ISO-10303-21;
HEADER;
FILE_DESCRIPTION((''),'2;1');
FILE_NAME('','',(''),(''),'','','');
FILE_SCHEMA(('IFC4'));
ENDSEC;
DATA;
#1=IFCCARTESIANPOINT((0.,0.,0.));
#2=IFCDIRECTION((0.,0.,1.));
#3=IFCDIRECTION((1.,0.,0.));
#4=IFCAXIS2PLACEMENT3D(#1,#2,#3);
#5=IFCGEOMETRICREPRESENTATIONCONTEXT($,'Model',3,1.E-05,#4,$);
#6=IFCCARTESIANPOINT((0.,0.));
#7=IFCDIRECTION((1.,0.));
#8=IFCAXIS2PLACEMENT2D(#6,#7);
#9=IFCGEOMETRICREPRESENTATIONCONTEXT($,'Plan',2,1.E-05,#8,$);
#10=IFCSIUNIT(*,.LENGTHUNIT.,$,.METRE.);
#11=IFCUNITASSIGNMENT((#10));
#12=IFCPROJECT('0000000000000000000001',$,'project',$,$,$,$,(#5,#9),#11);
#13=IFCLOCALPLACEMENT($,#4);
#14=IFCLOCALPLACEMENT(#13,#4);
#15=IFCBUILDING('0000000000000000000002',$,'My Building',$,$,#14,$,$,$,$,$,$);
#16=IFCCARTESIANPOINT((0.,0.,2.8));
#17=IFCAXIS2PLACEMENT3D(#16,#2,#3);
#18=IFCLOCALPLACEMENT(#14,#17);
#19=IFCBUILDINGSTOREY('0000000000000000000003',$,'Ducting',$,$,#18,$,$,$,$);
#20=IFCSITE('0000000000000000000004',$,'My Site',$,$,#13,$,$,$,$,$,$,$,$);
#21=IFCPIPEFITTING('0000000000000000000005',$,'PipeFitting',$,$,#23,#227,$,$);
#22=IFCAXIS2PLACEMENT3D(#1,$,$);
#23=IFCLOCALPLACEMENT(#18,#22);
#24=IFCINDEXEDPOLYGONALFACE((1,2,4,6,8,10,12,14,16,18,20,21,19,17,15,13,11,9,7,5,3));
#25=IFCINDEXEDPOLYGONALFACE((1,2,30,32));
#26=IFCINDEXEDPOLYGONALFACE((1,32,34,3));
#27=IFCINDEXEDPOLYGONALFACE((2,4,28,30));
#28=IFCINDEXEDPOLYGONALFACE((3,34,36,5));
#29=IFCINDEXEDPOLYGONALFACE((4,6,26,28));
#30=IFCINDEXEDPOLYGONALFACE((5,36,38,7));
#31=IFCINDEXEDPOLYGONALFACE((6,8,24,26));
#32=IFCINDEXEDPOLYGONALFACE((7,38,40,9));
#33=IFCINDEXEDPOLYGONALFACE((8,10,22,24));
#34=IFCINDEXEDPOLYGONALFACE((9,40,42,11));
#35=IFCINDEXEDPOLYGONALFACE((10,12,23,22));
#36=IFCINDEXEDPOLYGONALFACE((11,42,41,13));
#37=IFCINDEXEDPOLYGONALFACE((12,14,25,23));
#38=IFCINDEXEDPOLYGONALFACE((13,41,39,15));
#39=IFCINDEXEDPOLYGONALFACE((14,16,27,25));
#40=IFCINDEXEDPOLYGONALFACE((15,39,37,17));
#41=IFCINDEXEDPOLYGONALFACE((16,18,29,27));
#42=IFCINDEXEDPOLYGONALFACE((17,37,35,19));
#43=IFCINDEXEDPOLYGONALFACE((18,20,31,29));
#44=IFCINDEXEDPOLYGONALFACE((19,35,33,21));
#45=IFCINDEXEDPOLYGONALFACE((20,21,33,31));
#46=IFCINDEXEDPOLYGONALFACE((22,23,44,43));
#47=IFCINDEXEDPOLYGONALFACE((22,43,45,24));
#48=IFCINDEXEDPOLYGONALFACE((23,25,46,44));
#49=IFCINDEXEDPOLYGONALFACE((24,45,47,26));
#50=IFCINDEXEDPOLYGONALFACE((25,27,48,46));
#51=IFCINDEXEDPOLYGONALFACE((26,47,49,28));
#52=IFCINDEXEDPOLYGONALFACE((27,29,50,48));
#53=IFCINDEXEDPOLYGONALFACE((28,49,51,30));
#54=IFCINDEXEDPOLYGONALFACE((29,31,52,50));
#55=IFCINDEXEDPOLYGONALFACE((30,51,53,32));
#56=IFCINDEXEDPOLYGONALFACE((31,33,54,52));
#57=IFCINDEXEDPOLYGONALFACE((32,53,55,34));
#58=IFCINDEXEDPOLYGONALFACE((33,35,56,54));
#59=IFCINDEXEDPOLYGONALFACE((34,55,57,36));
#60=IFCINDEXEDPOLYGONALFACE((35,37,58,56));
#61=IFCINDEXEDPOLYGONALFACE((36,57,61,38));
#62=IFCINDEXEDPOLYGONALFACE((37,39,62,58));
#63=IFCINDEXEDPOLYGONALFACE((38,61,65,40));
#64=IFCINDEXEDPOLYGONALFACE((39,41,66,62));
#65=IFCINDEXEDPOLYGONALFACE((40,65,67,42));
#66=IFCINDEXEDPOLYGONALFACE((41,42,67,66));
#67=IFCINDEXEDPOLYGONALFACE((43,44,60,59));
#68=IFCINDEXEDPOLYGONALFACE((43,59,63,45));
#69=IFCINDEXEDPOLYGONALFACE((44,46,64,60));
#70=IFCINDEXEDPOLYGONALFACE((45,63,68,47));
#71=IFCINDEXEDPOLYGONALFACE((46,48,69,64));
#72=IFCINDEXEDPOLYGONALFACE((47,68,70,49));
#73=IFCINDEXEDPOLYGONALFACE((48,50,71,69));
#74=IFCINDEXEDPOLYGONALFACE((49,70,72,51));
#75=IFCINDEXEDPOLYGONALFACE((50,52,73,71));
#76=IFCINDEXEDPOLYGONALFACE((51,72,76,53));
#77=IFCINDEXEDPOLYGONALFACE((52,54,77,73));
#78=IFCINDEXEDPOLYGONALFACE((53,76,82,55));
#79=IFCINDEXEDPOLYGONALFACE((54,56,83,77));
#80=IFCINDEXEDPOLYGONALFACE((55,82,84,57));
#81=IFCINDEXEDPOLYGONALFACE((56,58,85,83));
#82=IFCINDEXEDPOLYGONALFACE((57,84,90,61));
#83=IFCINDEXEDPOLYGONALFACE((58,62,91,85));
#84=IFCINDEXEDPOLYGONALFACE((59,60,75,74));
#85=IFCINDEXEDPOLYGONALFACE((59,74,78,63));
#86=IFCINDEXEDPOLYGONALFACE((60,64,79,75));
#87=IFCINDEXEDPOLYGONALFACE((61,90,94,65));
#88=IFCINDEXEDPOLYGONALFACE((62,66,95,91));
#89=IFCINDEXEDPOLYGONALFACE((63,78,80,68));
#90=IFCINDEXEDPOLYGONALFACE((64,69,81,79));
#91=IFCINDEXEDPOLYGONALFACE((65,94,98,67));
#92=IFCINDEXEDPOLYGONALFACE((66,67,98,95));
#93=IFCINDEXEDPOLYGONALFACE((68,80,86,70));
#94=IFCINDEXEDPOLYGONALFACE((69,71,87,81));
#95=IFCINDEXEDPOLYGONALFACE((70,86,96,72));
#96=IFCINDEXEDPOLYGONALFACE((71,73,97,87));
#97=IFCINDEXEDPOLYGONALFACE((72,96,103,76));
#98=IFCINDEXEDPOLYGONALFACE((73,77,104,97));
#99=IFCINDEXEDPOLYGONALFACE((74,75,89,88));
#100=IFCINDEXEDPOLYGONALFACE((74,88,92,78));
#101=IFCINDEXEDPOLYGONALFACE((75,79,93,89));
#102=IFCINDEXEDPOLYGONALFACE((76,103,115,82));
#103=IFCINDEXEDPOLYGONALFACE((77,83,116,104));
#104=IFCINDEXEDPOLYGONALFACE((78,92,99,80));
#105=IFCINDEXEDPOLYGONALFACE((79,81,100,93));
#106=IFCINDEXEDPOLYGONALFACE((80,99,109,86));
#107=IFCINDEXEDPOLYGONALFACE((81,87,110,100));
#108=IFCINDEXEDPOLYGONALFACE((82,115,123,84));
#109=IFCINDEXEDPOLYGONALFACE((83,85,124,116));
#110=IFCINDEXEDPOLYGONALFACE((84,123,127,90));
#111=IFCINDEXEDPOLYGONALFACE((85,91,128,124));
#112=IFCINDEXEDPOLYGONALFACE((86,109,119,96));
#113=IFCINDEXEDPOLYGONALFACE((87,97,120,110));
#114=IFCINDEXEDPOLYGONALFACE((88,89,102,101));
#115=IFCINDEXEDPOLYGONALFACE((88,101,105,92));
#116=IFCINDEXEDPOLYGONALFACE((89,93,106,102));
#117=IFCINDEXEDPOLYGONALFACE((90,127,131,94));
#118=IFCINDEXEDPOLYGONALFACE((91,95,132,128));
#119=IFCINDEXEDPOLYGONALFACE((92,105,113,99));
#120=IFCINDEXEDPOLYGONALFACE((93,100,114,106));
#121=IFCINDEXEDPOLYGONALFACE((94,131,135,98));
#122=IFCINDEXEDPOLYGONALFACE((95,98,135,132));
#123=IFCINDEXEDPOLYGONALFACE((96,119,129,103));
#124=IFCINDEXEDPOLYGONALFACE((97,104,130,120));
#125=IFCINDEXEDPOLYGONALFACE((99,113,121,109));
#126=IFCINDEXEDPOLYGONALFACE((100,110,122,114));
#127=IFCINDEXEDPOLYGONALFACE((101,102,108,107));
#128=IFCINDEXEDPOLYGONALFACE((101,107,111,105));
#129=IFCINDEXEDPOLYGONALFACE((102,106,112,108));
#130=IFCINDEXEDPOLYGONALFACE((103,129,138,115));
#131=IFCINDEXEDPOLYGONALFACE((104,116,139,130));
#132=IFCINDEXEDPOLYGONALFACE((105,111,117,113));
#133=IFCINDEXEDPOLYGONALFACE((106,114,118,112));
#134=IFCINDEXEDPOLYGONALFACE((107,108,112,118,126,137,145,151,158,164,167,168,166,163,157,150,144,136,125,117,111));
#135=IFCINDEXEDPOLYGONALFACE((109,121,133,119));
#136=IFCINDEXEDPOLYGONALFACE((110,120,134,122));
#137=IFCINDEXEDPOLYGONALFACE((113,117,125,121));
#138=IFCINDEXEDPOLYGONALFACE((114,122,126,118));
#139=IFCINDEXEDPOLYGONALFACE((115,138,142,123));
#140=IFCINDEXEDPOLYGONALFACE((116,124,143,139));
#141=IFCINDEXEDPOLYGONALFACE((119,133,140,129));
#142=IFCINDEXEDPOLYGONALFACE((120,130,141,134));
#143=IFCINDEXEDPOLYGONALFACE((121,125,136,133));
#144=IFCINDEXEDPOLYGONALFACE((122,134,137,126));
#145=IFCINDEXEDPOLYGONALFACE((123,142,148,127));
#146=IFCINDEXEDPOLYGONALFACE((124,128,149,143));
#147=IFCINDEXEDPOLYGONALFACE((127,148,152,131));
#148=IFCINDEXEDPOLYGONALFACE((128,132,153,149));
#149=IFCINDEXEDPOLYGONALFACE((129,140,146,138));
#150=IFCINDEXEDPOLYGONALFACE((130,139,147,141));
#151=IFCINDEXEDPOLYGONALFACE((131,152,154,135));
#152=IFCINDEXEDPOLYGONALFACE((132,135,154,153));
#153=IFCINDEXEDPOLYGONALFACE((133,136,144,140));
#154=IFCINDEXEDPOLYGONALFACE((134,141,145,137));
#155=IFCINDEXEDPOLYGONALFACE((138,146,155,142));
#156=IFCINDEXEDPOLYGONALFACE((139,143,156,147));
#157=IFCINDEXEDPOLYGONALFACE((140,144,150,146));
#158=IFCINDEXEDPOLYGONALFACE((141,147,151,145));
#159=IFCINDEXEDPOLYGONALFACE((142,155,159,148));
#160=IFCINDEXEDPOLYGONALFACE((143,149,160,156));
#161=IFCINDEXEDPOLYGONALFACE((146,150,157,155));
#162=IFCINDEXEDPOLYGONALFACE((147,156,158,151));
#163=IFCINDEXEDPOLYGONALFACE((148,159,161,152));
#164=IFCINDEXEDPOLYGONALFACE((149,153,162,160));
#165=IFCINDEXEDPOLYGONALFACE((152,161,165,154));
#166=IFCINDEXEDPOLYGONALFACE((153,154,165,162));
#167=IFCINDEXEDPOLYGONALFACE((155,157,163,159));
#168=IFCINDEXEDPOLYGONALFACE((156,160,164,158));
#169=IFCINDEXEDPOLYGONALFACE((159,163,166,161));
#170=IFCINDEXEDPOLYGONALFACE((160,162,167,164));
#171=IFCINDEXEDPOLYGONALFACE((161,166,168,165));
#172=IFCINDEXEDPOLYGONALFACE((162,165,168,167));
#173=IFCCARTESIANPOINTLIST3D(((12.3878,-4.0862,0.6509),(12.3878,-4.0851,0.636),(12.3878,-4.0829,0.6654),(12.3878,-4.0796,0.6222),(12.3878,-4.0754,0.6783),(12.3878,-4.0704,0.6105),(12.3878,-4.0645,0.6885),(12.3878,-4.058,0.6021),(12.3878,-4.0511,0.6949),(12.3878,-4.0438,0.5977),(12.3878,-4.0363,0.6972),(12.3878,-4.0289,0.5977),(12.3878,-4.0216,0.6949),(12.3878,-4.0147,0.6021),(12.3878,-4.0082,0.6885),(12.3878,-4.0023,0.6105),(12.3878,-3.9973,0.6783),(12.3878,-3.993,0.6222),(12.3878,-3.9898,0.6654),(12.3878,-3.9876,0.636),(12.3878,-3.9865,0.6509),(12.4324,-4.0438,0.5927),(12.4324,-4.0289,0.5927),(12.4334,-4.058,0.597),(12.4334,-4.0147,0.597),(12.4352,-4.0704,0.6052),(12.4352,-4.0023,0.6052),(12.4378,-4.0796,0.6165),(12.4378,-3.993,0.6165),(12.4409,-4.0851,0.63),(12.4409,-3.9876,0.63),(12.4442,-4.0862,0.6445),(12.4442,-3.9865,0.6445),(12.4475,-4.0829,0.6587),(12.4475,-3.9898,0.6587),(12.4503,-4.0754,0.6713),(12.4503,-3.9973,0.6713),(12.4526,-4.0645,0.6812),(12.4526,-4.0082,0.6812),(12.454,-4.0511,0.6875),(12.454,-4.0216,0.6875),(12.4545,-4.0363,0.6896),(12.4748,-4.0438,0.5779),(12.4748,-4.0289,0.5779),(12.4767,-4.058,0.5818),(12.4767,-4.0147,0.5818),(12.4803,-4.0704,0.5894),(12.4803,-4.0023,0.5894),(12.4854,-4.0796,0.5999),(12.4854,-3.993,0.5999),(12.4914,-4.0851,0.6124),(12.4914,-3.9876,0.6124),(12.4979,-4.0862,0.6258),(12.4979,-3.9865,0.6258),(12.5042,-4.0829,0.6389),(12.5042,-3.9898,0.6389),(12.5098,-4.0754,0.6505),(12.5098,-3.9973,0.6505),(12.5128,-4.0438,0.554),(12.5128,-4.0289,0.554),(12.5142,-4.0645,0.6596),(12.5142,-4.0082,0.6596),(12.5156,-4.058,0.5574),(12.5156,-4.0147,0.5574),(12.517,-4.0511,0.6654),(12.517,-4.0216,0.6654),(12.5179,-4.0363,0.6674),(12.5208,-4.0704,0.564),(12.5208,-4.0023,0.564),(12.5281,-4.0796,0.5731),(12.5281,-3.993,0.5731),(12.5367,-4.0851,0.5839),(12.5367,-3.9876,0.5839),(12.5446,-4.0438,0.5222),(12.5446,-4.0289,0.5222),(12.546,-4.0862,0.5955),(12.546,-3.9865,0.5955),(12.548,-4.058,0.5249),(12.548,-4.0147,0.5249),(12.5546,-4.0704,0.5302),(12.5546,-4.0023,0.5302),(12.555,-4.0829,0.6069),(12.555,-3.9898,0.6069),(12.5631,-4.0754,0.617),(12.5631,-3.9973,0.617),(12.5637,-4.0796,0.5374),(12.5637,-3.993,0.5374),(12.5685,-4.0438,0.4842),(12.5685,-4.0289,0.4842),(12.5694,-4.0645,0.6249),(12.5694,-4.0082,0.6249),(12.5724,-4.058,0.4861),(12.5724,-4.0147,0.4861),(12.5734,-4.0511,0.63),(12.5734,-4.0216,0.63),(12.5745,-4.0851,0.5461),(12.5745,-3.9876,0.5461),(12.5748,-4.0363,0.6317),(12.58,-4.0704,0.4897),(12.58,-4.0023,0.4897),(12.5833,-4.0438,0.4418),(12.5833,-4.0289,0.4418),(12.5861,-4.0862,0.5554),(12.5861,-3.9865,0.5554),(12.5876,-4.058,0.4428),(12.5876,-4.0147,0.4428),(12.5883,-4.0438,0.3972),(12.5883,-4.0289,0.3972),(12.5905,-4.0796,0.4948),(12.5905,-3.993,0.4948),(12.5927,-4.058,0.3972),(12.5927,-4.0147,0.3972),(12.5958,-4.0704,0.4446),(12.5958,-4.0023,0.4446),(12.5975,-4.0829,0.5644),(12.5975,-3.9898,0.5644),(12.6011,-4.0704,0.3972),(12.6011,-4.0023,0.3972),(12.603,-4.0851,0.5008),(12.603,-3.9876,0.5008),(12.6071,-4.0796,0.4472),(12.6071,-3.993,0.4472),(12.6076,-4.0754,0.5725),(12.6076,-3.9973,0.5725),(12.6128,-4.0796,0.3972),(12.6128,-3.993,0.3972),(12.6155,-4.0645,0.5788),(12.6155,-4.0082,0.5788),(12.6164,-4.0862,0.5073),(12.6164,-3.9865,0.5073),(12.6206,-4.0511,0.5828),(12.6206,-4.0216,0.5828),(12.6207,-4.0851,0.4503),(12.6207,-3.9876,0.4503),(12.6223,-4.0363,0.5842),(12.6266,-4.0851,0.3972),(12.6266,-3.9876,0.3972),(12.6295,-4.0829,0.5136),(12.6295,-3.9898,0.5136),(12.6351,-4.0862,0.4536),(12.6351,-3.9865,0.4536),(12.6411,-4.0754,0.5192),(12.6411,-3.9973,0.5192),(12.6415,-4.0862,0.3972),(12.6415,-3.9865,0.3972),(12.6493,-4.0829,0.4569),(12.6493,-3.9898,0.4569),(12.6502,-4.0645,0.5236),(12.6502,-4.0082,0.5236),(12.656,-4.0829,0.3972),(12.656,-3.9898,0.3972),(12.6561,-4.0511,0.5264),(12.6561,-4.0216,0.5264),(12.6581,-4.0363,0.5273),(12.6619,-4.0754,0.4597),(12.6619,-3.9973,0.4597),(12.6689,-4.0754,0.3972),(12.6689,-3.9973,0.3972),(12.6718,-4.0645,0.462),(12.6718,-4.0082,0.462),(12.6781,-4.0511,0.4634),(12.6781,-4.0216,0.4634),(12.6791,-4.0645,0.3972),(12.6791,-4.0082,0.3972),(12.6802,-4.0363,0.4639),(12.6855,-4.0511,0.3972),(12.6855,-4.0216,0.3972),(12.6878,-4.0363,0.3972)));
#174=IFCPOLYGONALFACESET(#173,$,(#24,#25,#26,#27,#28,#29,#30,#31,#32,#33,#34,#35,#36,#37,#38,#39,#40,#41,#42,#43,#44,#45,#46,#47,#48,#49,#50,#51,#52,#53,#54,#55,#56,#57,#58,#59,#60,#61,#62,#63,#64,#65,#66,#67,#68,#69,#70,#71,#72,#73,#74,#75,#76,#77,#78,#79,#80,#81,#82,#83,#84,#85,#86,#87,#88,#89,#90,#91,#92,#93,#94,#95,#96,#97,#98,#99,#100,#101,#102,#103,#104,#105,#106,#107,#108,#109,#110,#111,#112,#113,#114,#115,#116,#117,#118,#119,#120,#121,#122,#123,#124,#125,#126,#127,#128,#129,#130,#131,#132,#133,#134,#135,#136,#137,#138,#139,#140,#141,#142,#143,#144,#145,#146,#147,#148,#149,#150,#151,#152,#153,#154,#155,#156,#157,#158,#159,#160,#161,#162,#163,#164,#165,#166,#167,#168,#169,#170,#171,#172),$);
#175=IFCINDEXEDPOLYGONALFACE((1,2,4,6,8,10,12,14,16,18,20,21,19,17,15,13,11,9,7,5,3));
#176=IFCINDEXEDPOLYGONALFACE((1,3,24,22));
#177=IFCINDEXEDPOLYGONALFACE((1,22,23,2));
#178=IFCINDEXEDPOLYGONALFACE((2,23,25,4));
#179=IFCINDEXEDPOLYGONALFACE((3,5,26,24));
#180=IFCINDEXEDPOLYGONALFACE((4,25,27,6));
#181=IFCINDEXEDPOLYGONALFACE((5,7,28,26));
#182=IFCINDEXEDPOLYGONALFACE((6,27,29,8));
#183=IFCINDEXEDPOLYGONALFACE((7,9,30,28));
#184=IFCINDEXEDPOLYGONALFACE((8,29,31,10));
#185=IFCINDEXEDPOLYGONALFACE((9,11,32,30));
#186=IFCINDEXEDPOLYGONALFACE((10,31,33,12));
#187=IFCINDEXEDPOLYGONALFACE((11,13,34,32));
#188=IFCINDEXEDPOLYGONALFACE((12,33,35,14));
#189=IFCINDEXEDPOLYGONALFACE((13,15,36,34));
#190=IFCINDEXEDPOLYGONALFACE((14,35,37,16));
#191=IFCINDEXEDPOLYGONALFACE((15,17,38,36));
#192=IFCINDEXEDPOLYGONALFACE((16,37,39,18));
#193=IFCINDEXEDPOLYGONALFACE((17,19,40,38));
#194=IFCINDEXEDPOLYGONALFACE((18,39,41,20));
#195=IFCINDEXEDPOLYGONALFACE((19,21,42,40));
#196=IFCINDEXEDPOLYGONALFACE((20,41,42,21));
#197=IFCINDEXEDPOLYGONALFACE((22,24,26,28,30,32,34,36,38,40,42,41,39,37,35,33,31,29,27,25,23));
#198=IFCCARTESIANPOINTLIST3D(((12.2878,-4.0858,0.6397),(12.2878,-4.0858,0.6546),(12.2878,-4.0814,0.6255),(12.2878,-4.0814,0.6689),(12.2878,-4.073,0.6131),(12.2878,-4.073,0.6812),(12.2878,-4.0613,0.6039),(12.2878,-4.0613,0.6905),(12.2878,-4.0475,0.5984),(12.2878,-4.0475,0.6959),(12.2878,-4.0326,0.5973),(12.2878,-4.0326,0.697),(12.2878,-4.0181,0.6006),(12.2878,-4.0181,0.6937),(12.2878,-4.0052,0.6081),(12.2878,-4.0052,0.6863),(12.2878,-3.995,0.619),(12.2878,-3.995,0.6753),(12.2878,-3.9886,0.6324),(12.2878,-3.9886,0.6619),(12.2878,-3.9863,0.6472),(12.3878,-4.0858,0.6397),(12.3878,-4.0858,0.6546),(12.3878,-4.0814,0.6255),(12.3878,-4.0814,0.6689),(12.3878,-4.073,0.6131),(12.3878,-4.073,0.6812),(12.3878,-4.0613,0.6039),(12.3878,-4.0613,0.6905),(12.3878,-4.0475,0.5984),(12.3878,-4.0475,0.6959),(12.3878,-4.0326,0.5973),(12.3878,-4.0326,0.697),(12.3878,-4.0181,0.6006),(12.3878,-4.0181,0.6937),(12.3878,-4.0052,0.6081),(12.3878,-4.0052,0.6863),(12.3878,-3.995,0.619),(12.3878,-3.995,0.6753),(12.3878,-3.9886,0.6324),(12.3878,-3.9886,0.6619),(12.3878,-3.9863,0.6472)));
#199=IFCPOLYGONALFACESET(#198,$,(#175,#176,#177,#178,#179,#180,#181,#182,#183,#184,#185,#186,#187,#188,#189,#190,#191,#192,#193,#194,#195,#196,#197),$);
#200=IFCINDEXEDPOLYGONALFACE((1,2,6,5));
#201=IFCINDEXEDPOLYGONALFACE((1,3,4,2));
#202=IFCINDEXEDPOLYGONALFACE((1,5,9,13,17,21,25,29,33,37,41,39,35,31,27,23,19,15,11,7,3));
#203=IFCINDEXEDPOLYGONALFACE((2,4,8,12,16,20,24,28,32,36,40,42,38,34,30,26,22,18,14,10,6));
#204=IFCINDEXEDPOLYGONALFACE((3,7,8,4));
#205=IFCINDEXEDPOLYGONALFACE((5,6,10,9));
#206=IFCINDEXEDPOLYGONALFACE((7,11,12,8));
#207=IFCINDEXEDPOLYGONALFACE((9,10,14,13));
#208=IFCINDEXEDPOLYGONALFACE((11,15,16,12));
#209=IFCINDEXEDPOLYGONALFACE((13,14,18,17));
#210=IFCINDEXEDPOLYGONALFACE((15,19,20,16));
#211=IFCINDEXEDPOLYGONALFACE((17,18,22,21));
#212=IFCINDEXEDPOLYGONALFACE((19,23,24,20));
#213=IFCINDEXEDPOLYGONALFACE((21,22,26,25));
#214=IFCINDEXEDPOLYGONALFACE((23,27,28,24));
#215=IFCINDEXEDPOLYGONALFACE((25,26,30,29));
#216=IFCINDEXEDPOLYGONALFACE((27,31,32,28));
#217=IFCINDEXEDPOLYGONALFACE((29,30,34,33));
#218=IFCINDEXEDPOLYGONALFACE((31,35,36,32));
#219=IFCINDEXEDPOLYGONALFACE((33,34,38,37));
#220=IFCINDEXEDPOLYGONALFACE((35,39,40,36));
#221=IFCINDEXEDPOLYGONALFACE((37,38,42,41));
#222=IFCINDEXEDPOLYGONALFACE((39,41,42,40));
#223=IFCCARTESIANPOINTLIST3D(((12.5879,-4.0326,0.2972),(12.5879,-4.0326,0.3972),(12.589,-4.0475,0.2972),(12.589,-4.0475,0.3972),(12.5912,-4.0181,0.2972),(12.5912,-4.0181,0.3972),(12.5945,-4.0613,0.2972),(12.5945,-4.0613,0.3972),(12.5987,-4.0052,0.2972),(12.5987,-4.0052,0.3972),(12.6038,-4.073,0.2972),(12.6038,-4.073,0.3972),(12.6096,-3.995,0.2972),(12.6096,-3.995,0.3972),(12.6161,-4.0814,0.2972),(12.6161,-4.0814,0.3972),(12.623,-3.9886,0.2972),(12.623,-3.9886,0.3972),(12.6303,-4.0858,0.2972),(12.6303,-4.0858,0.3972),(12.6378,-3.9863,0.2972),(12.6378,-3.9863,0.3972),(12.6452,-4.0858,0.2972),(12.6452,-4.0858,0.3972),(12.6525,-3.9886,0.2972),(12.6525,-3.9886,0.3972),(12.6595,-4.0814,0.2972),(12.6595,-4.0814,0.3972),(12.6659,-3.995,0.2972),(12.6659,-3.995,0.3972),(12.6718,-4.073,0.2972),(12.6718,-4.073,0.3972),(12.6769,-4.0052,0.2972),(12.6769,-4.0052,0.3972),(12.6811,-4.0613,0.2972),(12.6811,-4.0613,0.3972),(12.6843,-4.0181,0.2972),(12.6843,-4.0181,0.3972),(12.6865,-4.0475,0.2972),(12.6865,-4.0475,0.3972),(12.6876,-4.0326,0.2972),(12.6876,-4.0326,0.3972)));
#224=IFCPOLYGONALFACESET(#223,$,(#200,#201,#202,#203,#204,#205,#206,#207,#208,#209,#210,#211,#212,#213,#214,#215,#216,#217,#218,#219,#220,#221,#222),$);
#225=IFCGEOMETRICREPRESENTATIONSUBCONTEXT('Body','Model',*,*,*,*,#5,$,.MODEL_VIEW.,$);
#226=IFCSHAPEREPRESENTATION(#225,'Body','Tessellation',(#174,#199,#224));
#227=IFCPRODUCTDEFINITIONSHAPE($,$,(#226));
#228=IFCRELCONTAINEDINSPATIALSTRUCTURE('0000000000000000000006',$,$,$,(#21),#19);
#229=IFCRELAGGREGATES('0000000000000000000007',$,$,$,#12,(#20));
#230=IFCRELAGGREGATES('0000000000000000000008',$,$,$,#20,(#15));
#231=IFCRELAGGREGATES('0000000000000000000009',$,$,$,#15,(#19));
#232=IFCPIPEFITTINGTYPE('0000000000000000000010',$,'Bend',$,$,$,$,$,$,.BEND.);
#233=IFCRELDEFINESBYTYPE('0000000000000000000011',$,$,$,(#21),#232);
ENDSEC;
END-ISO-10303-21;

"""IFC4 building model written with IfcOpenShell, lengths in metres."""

from ifc_helpers import new_model, entity, si_unit, frame, origin_with_axes, origin_2d_with_axis, place, context, subcontext, project, spatial, circle, extrude, source, transform, mapped, type_object, type_shapes, element, save


model = new_model("IFC4")

# Units and contexts
model_context = context("Model", 3, precision=1e-05, world=origin_with_axes())
plan_context = context("Plan", 2, precision=1e-05, world=origin_2d_with_axis())
body_context = subcontext(model_context, "Body", "Model", "MODEL_VIEW")
ifc_project = project(units=[si_unit("LENGTHUNIT", "METRE")], contexts=[model_context, plan_context])

# Site, building, storey
site_placement = place(None, origin_with_axes())
site = spatial("IfcSite", under=ifc_project, at=site_placement, Name="My Site")
building_placement = place(site_placement, origin_with_axes())
building = spatial("IfcBuilding", under=site, at=building_placement, Name="My Building")
storey_placement = place(building_placement, frame((0.0, 0.0, 2.8), z_axis=(0.0, 0.0, 1.0), x_axis=(1.0, 0.0, 0.0)))
storey = spatial("IfcBuildingStorey", under=building, at=storey_placement, Name="Ducting")

# Pipe fitting
pipe_fitting_type = type_object("IfcPipeFittingType", Name="Bend", PredefinedType="BEND")
shared_shape_1 = source(origin_with_axes(), body_context, "Body", "SolidModel", [
    entity("IfcSweptDiskSolid", entity("IfcIndexedPolyCurve", entity("IfcCartesianPointList3D", [[0.0, 0.0, 0.1], [0.0, -0.0732, 0.2768], [0.0, -0.25, 0.35]]), [entity("IfcArcIndex", [1, 2, 3])]), 0.05),
    extrude(circle(Radius=0.05), origin_with_axes(), (0.0, 0.0, 1.0), 0.1),
    extrude(circle(Radius=0.05), frame((0.0, -0.25, 0.35), z_axis=(0.0, -1.0, 0.0), x_axis=(1.0, 0.0, 0.0)), (0.0, 0.0, 1.0), 0.1),
])
type_shapes(pipe_fitting_type, [shared_shape_1])
for number, where, z_axis, x_axis, name in (
    (1, (12.2878, -4.0363, 0.6472), (1.0, 0.0, 0.0), (0.0, 1.0, 0.0), "PipeFitting"),
):
    element("IfcPipeFitting", number, at=place(storey_placement, frame(where, z_axis=z_axis, x_axis=x_axis)), inside=storey, type_object=pipe_fitting_type, Name=name, context=body_context, shape_type="MappedRepresentation", body=[
        mapped(shared_shape_1, transform((0.0, 0.0, 0.0), x_axis=(1.0, 0.0, 0.0), y_axis=(0.0, 1.0, 0.0), z_axis=(0.0, 0.0, 1.0), scale=1.0)),
    ])

save(model, "model.ifc")
